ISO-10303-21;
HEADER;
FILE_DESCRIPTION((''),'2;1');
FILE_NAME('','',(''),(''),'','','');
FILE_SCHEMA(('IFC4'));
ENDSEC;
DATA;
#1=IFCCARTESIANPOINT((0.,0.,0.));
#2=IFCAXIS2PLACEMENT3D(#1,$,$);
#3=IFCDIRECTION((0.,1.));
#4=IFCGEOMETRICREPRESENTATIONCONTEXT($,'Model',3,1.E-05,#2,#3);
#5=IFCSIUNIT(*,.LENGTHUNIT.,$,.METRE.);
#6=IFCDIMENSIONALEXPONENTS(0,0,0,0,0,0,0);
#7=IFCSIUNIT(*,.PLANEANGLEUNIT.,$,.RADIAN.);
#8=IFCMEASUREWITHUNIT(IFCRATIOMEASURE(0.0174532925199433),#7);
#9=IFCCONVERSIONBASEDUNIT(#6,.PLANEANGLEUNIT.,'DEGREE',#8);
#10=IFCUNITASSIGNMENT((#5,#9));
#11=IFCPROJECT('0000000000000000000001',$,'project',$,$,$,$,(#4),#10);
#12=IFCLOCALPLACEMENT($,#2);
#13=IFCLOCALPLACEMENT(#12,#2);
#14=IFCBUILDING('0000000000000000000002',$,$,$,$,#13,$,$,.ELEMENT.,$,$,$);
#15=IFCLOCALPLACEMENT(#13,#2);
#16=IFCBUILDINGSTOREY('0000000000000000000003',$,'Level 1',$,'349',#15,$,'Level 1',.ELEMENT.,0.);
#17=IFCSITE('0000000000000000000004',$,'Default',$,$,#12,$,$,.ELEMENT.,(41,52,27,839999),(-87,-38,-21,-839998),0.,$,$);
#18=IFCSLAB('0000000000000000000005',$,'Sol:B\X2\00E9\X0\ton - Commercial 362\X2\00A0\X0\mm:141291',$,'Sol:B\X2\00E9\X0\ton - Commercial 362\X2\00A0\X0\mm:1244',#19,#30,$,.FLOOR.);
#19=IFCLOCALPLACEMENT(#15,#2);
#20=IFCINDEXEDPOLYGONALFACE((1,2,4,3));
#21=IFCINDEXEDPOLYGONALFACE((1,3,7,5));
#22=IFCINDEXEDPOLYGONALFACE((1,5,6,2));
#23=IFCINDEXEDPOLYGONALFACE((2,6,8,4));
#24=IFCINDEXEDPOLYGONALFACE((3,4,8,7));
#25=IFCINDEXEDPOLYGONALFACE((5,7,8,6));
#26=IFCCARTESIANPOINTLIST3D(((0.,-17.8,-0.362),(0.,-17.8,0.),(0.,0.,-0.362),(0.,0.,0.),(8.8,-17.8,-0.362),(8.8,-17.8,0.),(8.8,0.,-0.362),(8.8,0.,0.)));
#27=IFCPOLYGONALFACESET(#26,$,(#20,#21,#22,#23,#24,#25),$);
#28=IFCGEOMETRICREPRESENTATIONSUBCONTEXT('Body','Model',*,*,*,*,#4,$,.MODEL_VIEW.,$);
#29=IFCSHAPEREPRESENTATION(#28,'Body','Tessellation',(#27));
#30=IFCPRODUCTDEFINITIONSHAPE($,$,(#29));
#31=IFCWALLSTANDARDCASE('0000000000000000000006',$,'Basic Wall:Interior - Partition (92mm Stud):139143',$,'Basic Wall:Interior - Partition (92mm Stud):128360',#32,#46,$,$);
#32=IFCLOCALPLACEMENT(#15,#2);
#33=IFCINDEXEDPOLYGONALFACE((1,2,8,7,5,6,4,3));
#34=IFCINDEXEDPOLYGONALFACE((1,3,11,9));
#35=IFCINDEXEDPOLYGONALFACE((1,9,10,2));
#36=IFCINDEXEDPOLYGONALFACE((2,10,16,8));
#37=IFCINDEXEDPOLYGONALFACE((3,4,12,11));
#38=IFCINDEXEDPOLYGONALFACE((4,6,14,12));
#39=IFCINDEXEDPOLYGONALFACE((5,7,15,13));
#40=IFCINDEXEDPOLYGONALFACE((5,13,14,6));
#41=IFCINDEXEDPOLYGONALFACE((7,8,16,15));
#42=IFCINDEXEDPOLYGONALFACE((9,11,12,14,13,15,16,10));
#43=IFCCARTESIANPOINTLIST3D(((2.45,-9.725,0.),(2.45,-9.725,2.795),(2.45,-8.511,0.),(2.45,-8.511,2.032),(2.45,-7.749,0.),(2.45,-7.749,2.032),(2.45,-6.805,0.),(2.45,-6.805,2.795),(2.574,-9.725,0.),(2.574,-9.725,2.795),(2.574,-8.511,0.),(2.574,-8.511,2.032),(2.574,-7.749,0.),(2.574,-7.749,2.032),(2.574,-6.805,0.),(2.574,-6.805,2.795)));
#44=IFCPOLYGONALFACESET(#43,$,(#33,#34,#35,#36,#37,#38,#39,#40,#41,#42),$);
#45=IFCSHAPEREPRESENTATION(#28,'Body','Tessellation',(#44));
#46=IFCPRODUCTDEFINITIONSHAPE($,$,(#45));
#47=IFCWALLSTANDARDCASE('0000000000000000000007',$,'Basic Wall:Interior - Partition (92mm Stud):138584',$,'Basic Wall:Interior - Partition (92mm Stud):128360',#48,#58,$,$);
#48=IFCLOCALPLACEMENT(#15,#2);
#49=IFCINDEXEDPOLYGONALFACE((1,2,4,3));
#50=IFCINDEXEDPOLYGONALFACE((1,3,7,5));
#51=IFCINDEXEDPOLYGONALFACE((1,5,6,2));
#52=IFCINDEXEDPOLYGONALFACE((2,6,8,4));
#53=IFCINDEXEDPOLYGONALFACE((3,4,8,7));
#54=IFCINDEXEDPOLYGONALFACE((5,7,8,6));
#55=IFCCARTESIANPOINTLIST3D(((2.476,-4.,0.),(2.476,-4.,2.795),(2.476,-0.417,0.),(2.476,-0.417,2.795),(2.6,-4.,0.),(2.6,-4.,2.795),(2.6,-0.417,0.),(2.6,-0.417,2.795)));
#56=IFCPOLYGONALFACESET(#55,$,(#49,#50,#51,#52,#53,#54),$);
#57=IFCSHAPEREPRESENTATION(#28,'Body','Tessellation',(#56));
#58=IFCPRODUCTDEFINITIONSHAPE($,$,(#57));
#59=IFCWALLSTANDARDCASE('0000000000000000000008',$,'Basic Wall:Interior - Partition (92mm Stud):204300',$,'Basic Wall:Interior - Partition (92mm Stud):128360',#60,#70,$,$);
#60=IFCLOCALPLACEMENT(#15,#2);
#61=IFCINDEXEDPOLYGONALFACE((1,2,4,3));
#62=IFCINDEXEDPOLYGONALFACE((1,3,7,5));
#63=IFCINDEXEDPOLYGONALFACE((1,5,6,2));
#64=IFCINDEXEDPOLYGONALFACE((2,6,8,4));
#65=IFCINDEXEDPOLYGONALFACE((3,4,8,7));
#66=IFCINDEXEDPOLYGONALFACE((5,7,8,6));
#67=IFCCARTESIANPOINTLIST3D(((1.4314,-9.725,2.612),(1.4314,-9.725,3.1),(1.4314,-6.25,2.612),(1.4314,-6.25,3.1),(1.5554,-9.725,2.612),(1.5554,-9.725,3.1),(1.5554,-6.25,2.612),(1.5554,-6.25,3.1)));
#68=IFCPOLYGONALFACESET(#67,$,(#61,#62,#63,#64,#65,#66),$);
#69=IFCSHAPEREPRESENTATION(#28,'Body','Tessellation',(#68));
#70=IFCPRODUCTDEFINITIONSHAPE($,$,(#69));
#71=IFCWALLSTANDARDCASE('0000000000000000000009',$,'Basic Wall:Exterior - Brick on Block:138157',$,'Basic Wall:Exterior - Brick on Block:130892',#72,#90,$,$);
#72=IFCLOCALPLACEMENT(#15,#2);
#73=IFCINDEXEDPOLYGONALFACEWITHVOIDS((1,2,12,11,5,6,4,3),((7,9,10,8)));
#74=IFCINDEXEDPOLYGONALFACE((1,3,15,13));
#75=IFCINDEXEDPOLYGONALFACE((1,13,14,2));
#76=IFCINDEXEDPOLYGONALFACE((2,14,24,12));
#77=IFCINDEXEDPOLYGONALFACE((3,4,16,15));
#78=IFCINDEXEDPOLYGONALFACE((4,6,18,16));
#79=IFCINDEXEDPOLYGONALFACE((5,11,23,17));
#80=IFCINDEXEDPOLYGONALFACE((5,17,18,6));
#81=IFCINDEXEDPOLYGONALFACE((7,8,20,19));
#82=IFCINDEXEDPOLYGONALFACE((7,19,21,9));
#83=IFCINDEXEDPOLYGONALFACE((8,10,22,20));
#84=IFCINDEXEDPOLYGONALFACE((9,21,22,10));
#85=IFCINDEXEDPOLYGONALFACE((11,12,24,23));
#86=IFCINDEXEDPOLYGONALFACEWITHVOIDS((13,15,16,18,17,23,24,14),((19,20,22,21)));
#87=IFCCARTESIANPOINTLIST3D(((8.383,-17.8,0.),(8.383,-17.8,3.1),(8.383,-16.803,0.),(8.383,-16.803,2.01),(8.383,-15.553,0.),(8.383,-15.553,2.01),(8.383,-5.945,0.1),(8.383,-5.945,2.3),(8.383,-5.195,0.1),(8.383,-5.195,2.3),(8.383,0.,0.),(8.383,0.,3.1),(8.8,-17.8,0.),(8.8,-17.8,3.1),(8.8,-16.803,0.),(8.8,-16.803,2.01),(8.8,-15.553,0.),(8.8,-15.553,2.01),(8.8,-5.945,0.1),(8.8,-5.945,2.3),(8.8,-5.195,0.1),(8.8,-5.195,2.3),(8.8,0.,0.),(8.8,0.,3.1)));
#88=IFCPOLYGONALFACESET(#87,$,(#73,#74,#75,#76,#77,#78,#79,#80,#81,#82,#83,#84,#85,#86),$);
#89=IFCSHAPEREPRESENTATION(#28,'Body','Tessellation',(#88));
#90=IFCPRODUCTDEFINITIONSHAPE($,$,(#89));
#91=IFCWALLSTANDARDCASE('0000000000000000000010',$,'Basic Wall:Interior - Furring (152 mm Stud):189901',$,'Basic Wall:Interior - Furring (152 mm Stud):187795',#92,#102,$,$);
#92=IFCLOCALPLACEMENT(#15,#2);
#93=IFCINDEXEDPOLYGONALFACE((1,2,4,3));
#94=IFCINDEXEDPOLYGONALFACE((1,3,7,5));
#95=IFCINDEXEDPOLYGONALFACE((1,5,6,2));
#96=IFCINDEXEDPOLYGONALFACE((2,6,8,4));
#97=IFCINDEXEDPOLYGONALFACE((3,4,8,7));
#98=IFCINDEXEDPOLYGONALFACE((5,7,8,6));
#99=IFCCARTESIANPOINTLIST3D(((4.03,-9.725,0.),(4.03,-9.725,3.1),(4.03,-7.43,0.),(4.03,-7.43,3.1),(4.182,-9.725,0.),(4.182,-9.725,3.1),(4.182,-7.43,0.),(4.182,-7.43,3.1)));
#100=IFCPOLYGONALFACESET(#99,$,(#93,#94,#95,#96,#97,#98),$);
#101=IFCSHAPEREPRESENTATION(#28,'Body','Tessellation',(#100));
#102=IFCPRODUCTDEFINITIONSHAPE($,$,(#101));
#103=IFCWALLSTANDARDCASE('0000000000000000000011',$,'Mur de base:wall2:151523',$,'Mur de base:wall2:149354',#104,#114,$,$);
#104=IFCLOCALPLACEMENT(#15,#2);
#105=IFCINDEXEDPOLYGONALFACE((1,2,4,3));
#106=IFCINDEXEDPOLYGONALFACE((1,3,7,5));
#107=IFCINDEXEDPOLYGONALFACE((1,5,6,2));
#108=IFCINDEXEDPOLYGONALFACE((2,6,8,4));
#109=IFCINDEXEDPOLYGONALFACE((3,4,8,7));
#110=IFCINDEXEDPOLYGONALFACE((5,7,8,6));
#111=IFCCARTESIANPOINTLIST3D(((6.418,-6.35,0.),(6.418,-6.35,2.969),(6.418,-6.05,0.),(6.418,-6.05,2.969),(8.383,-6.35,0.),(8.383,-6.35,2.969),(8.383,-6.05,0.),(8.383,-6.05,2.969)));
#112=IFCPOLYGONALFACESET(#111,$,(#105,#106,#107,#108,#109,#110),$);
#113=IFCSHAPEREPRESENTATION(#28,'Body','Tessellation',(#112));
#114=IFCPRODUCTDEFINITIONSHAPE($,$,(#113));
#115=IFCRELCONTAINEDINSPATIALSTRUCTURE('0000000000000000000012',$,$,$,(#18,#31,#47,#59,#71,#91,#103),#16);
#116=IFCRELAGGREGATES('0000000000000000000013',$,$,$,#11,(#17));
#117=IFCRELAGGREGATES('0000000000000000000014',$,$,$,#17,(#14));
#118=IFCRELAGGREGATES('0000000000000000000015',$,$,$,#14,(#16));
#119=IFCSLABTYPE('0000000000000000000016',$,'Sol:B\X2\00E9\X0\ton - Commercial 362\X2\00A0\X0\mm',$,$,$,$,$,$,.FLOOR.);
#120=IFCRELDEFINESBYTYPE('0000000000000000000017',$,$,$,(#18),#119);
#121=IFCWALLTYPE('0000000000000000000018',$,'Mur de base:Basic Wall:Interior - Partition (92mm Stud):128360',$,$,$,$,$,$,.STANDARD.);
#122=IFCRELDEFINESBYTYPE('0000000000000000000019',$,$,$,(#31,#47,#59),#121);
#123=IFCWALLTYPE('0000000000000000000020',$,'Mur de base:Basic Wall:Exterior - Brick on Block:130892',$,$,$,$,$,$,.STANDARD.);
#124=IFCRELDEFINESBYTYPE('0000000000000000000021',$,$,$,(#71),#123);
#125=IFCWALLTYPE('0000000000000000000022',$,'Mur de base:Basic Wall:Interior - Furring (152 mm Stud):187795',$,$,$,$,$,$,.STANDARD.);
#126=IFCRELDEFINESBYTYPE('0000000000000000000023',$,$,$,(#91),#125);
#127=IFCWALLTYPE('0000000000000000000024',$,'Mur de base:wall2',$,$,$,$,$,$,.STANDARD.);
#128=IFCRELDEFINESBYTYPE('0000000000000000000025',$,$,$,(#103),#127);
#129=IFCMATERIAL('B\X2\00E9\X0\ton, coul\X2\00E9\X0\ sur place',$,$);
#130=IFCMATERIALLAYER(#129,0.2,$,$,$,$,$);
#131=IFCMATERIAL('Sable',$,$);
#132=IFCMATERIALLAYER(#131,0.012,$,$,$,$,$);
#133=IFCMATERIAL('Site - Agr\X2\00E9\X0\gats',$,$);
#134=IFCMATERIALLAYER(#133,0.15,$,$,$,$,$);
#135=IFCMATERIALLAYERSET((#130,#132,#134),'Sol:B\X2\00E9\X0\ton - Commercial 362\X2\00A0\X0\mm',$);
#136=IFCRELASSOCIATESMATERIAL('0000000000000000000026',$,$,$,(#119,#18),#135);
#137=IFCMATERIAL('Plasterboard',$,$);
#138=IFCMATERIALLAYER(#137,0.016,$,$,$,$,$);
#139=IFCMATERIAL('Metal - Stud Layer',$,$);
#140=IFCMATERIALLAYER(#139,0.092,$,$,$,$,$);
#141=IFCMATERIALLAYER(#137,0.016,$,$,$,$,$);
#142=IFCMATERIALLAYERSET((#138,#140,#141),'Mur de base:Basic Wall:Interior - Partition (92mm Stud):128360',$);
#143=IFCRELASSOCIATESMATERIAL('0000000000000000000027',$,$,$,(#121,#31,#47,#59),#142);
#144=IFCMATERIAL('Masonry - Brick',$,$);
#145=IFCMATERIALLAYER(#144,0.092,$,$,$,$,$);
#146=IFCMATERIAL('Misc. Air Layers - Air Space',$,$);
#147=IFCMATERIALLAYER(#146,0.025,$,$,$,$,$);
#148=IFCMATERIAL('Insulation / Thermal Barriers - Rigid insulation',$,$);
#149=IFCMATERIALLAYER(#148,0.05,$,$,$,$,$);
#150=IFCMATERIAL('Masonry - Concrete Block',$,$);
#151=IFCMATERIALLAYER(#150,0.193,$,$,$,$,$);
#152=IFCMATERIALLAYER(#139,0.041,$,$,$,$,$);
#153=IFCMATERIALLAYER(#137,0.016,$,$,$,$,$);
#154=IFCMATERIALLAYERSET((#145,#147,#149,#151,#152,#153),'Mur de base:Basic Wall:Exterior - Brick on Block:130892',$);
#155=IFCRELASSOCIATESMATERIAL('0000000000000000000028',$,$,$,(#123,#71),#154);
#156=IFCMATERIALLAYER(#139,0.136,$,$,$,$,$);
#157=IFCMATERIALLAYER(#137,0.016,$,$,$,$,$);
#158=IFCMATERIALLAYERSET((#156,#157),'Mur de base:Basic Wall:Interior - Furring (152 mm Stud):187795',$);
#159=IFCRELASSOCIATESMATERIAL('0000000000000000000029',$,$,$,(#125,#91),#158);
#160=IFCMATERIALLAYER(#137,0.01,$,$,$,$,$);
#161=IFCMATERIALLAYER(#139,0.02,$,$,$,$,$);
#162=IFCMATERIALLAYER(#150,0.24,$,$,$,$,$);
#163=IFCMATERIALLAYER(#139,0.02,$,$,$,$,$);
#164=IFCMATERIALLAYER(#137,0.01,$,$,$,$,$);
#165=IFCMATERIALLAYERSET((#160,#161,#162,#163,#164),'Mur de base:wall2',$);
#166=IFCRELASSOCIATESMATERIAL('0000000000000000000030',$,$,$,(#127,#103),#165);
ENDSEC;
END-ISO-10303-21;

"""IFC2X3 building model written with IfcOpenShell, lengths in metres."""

from ifc_helpers import new_model, entity, si_unit, converted_unit, direction, frame, frame_2d, origin, origin_2d_with_axis, place, context, subcontext, project, spatial, polyline, rectangle, extrude, clip, bounded_halfspace, material, layer, layer_set, layer_usage, type_object, element, save


model = new_model("IFC2X3")

# Units and contexts
model_context = context("Model", 3, precision=1e-05, world=origin(), true_north=direction((0.0, 1.0)))
body_context = subcontext(model_context, "Body", "Model", "MODEL_VIEW")
ifc_project = project(units=[si_unit("LENGTHUNIT", "METRE"), converted_unit("PLANEANGLEUNIT", "DEGREE", entity("IfcRatioMeasure", 0.0174532925199433), si_unit("PLANEANGLEUNIT", "RADIAN"), dimensions=[0, 0, 0, 0, 0, 0, 0])], contexts=[model_context])

# Site, building, storey
site_placement = place(None, origin())
site = spatial("IfcSite", under=ifc_project, at=site_placement, Name="Default", CompositionType="ELEMENT", RefLatitude=(41, 52, 27, 839999), RefLongitude=(-87, -38, -21, -839998), RefElevation=0.0)
building_placement = place(site_placement, origin())
building = spatial("IfcBuilding", under=site, at=building_placement, CompositionType="ELEMENT")
storey_placement = place(building_placement, origin())
storey = spatial("IfcBuildingStorey", under=building, at=storey_placement, Name="Level 1", ObjectType="349", LongName="Level 1", CompositionType="ELEMENT", Elevation=0.0)

# Slab
ifc_material_1 = material(Name="Béton, coulé sur place")
ifc_layer_1 = layer(ifc_material_1, 0.2)
ifc_material_2 = material(Name="Sable")
ifc_layer_2 = layer(ifc_material_2, 0.012)
ifc_material_3 = material(Name="Site - Agrégats")
ifc_layer_3 = layer(ifc_material_3, 0.15)
ifc_layer_set_1 = layer_set([ifc_layer_1, ifc_layer_2, ifc_layer_3], Name="Sol:Béton - Commercial 362 mm")
ifc_layer_usage_1 = layer_usage(ifc_layer_set_1, "AXIS3", "POSITIVE", 0.0)
slab_type = type_object("IfcSlabType", Name="Sol:Béton - Commercial 362 mm", PredefinedType="FLOOR", material=ifc_layer_set_1)
slab_placement = place(storey_placement, origin())
element("IfcSlab", 1, at=slab_placement, inside=storey, type_object=slab_type, material=ifc_layer_usage_1, Name="Sol:Béton - Commercial 362 mm:141291", ObjectType="Sol:Béton - Commercial 362 mm:1244", PredefinedType="FLOOR", context=body_context, shape_type="SweptSolid", body=[
    extrude(rectangle(XDim=17.8, YDim=8.8, at=origin_2d_with_axis()), frame((4.4, -8.9, 0.0), z_axis=(0.0, 0.0, -1.0), x_axis=(0.0, 1.0, 0.0)), (0.0, 0.0, 1.0), 0.362),
])

# Wall, opening
ifc_material_4 = material(Name="Plasterboard")
ifc_layer_4 = layer(ifc_material_4, 0.016)
ifc_material_5 = material(Name="Metal - Stud Layer")
ifc_layer_5 = layer(ifc_material_5, 0.092)
ifc_layer_6 = layer(ifc_material_4, 0.016)
ifc_layer_set_2 = layer_set([ifc_layer_4, ifc_layer_5, ifc_layer_6], Name="Mur de base:Basic Wall:Interior - Partition (92mm Stud):128360")
wall_type_1 = type_object("IfcWallType", Name="Mur de base:Basic Wall:Interior - Partition (92mm Stud):128360", PredefinedType="STANDARD", material=ifc_layer_set_2)
ifc_layer_usage_2 = layer_usage(ifc_layer_set_2, "AXIS2", "NEGATIVE", 0.062)
wall_1_placement = place(storey_placement, frame((2.512, -6.805, 0.0), z_axis=(0.0, 0.0, 1.0), x_axis=(0.0, -1.0, 0.0)))
wall_1 = element("IfcWallStandardCase", 2, at=wall_1_placement, inside=storey, type_object=wall_type_1, material=ifc_layer_usage_2, Name="Basic Wall:Interior - Partition (92mm Stud):139143", ObjectType="Basic Wall:Interior - Partition (92mm Stud):128360", context=body_context, shape_type="SweptSolid", body=[
    extrude(rectangle(XDim=2.92, YDim=0.124, at=frame_2d((1.46, 0.0), x_axis=(-1.0, 0.0))), origin(), (0.0, 0.0, 1.0), 2.795),
])
opening_1_placement = place(wall_1_placement, origin())
element("IfcOpeningElement", 3, at=opening_1_placement, cuts=wall_1, ObjectType="Opening", context=body_context, shape_type="SweptSolid", body=[
    extrude(rectangle(XDim=2.032, YDim=0.762, at=origin_2d_with_axis()), frame((1.325, -0.0632, 1.016), z_axis=(0.0, 1.0, 0.0), x_axis=(0.0, 0.0, 1.0)), (0.0, 0.0, 1.0), 0.1265),
])

# Walls
ifc_layer_usage_3 = layer_usage(ifc_layer_set_2, "AXIS2", "NEGATIVE", 0.062)
wall_2_placement = place(storey_placement, frame((2.538, -0.417, 0.0), z_axis=(0.0, 0.0, 1.0), x_axis=(0.0, -1.0, 0.0)))
element("IfcWallStandardCase", 4, at=wall_2_placement, inside=storey, type_object=wall_type_1, material=ifc_layer_usage_3, Name="Basic Wall:Interior - Partition (92mm Stud):138584", ObjectType="Basic Wall:Interior - Partition (92mm Stud):128360", context=body_context, shape_type="SweptSolid", body=[
    extrude(rectangle(XDim=3.583, YDim=0.124, at=frame_2d((1.7915, 0.0), x_axis=(-1.0, 0.0))), origin(), (0.0, 0.0, 1.0), 2.795),
])
ifc_layer_usage_4 = layer_usage(ifc_layer_set_2, "AXIS2", "NEGATIVE", 0.062)
wall_3_placement = place(storey_placement, frame((1.4934, -6.25, 2.612), z_axis=(0.0, 0.0, 1.0), x_axis=(0.0, -1.0, 0.0)))
element("IfcWallStandardCase", 5, at=wall_3_placement, inside=storey, type_object=wall_type_1, material=ifc_layer_usage_4, Name="Basic Wall:Interior - Partition (92mm Stud):204300", ObjectType="Basic Wall:Interior - Partition (92mm Stud):128360", context=body_context, shape_type="SweptSolid", body=[
    extrude(rectangle(XDim=3.475, YDim=0.124, at=frame_2d((1.7375, 0.0), x_axis=(-1.0, 0.0))), origin(), (0.0, 0.0, 1.0), 0.488),
])

# Wall, openings
ifc_material_6 = material(Name="Masonry - Brick")
ifc_layer_7 = layer(ifc_material_6, 0.092)
ifc_material_7 = material(Name="Misc. Air Layers - Air Space")
ifc_layer_8 = layer(ifc_material_7, 0.025)
ifc_material_8 = material(Name="Insulation / Thermal Barriers - Rigid insulation")
ifc_layer_9 = layer(ifc_material_8, 0.05)
ifc_material_9 = material(Name="Masonry - Concrete Block")
ifc_layer_10 = layer(ifc_material_9, 0.193)
ifc_layer_11 = layer(ifc_material_5, 0.041)
ifc_layer_12 = layer(ifc_material_4, 0.016)
ifc_layer_set_3 = layer_set([ifc_layer_7, ifc_layer_8, ifc_layer_9, ifc_layer_10, ifc_layer_11, ifc_layer_12], Name="Mur de base:Basic Wall:Exterior - Brick on Block:130892")
ifc_layer_usage_5 = layer_usage(ifc_layer_set_3, "AXIS2", "NEGATIVE", 0.2085)
wall_type_2 = type_object("IfcWallType", Name="Mur de base:Basic Wall:Exterior - Brick on Block:130892", PredefinedType="STANDARD", material=ifc_layer_set_3)
wall_4_placement = place(storey_placement, frame((8.5915, 0.0, 0.0), z_axis=(0.0, 0.0, 1.0), x_axis=(0.0, -1.0, 0.0)))
wall_4 = element("IfcWallStandardCase", 6, at=wall_4_placement, inside=storey, type_object=wall_type_2, material=ifc_layer_usage_5, Name="Basic Wall:Exterior - Brick on Block:138157", ObjectType="Basic Wall:Exterior - Brick on Block:130892", context=body_context, shape_type="SweptSolid", body=[
    extrude(rectangle(XDim=17.8, YDim=0.417, at=frame_2d((8.9, 0.0), x_axis=(-1.0, 0.0))), origin(), (0.0, 0.0, 1.0), 3.1),
])
opening_2_placement = place(wall_4_placement, origin())
element("IfcOpeningElement", 7, at=opening_2_placement, cuts=wall_4, ObjectType="Opening", context=body_context, shape_type="SweptSolid", body=[
    extrude(rectangle(XDim=2.01, YDim=1.25, at=frame_2d((0.0, 0.0), x_axis=(1.0, 0.0))), frame((16.178, -0.2127, 1.005), z_axis=(0.0, 1.0, 0.0), x_axis=(0.0, 0.0, -1.0)), (0.0, 0.0, 1.0), 0.4253),
])
opening_3_placement = place(wall_4_placement, origin())
element("IfcOpeningElement", 8, at=opening_3_placement, cuts=wall_4, ObjectType="Opening", context=body_context, shape_type="SweptSolid", body=[
    extrude(rectangle(XDim=2.2, YDim=0.75, at=frame_2d((0.0, 0.0), x_axis=(0.0, 1.0))), frame((5.57, -0.2127, 1.2), z_axis=(0.0, 1.0, 0.0), x_axis=(1.0, 0.0, 0.0)), (0.0, 0.0, 1.0), 0.4253),
])

# Walls
ifc_layer_13 = layer(ifc_material_5, 0.136)
ifc_layer_14 = layer(ifc_material_4, 0.016)
ifc_layer_set_4 = layer_set([ifc_layer_13, ifc_layer_14], Name="Mur de base:Basic Wall:Interior - Furring (152 mm Stud):187795")
ifc_layer_usage_6 = layer_usage(ifc_layer_set_4, "AXIS2", "NEGATIVE", 0.076)
wall_type_3 = type_object("IfcWallType", Name="Mur de base:Basic Wall:Interior - Furring (152 mm Stud):187795", PredefinedType="STANDARD", material=ifc_layer_set_4)
wall_5_placement = place(storey_placement, frame((4.106, -7.43, 0.0), z_axis=(0.0, 0.0, 1.0), x_axis=(0.0, -1.0, 0.0)))
element("IfcWallStandardCase", 9, at=wall_5_placement, inside=storey, type_object=wall_type_3, material=ifc_layer_usage_6, Name="Basic Wall:Interior - Furring (152 mm Stud):189901", ObjectType="Basic Wall:Interior - Furring (152 mm Stud):187795", context=body_context, shape_type="SweptSolid", body=[
    extrude(rectangle(XDim=2.295, YDim=0.152, at=frame_2d((1.1475, 0.0), x_axis=(-1.0, 0.0))), origin(), (0.0, 0.0, 1.0), 3.1),
])
ifc_layer_15 = layer(ifc_material_4, 0.01)
ifc_layer_16 = layer(ifc_material_5, 0.02)
ifc_layer_17 = layer(ifc_material_9, 0.24)
ifc_layer_18 = layer(ifc_material_5, 0.02)
ifc_layer_19 = layer(ifc_material_4, 0.01)
ifc_layer_set_5 = layer_set([ifc_layer_15, ifc_layer_16, ifc_layer_17, ifc_layer_18, ifc_layer_19], Name="Mur de base:wall2")
ifc_layer_usage_7 = layer_usage(ifc_layer_set_5, "AXIS2", "NEGATIVE", 0.15)
wall_type_4 = type_object("IfcWallType", Name="Mur de base:wall2", PredefinedType="STANDARD", material=ifc_layer_set_5)
wall_6_placement = place(storey_placement, frame((8.383, -6.2, 0.0), z_axis=(0.0, 0.0, 1.0), x_axis=(-1.0, 0.0, 0.0)))
element("IfcWallStandardCase", 10, at=wall_6_placement, inside=storey, type_object=wall_type_4, material=ifc_layer_usage_7, Name="Mur de base:wall2:151523", ObjectType="Mur de base:wall2:149354", context=body_context, shape_type="Clipping", body=[
    clip(extrude(rectangle(XDim=1.965, YDim=0.3, at=frame_2d((0.9825, 0.0), x_axis=(-1.0, 0.0))), origin(), (0.0, 0.0, 1.0), 2.969), bounded_halfspace(frame((0.0, -0.15, 2.969), z_axis=(0.0, 0.0, -1.0), x_axis=(1.0, 0.0, 0.0)), True, frame((0.0, -0.15, 2.969)), polyline([(0.0, 0.0), (1.965, 0.0), (1.965, 0.3), (0.0, 0.3), (0.0, 0.0)]))),
])

save(model, "model.ifc")
